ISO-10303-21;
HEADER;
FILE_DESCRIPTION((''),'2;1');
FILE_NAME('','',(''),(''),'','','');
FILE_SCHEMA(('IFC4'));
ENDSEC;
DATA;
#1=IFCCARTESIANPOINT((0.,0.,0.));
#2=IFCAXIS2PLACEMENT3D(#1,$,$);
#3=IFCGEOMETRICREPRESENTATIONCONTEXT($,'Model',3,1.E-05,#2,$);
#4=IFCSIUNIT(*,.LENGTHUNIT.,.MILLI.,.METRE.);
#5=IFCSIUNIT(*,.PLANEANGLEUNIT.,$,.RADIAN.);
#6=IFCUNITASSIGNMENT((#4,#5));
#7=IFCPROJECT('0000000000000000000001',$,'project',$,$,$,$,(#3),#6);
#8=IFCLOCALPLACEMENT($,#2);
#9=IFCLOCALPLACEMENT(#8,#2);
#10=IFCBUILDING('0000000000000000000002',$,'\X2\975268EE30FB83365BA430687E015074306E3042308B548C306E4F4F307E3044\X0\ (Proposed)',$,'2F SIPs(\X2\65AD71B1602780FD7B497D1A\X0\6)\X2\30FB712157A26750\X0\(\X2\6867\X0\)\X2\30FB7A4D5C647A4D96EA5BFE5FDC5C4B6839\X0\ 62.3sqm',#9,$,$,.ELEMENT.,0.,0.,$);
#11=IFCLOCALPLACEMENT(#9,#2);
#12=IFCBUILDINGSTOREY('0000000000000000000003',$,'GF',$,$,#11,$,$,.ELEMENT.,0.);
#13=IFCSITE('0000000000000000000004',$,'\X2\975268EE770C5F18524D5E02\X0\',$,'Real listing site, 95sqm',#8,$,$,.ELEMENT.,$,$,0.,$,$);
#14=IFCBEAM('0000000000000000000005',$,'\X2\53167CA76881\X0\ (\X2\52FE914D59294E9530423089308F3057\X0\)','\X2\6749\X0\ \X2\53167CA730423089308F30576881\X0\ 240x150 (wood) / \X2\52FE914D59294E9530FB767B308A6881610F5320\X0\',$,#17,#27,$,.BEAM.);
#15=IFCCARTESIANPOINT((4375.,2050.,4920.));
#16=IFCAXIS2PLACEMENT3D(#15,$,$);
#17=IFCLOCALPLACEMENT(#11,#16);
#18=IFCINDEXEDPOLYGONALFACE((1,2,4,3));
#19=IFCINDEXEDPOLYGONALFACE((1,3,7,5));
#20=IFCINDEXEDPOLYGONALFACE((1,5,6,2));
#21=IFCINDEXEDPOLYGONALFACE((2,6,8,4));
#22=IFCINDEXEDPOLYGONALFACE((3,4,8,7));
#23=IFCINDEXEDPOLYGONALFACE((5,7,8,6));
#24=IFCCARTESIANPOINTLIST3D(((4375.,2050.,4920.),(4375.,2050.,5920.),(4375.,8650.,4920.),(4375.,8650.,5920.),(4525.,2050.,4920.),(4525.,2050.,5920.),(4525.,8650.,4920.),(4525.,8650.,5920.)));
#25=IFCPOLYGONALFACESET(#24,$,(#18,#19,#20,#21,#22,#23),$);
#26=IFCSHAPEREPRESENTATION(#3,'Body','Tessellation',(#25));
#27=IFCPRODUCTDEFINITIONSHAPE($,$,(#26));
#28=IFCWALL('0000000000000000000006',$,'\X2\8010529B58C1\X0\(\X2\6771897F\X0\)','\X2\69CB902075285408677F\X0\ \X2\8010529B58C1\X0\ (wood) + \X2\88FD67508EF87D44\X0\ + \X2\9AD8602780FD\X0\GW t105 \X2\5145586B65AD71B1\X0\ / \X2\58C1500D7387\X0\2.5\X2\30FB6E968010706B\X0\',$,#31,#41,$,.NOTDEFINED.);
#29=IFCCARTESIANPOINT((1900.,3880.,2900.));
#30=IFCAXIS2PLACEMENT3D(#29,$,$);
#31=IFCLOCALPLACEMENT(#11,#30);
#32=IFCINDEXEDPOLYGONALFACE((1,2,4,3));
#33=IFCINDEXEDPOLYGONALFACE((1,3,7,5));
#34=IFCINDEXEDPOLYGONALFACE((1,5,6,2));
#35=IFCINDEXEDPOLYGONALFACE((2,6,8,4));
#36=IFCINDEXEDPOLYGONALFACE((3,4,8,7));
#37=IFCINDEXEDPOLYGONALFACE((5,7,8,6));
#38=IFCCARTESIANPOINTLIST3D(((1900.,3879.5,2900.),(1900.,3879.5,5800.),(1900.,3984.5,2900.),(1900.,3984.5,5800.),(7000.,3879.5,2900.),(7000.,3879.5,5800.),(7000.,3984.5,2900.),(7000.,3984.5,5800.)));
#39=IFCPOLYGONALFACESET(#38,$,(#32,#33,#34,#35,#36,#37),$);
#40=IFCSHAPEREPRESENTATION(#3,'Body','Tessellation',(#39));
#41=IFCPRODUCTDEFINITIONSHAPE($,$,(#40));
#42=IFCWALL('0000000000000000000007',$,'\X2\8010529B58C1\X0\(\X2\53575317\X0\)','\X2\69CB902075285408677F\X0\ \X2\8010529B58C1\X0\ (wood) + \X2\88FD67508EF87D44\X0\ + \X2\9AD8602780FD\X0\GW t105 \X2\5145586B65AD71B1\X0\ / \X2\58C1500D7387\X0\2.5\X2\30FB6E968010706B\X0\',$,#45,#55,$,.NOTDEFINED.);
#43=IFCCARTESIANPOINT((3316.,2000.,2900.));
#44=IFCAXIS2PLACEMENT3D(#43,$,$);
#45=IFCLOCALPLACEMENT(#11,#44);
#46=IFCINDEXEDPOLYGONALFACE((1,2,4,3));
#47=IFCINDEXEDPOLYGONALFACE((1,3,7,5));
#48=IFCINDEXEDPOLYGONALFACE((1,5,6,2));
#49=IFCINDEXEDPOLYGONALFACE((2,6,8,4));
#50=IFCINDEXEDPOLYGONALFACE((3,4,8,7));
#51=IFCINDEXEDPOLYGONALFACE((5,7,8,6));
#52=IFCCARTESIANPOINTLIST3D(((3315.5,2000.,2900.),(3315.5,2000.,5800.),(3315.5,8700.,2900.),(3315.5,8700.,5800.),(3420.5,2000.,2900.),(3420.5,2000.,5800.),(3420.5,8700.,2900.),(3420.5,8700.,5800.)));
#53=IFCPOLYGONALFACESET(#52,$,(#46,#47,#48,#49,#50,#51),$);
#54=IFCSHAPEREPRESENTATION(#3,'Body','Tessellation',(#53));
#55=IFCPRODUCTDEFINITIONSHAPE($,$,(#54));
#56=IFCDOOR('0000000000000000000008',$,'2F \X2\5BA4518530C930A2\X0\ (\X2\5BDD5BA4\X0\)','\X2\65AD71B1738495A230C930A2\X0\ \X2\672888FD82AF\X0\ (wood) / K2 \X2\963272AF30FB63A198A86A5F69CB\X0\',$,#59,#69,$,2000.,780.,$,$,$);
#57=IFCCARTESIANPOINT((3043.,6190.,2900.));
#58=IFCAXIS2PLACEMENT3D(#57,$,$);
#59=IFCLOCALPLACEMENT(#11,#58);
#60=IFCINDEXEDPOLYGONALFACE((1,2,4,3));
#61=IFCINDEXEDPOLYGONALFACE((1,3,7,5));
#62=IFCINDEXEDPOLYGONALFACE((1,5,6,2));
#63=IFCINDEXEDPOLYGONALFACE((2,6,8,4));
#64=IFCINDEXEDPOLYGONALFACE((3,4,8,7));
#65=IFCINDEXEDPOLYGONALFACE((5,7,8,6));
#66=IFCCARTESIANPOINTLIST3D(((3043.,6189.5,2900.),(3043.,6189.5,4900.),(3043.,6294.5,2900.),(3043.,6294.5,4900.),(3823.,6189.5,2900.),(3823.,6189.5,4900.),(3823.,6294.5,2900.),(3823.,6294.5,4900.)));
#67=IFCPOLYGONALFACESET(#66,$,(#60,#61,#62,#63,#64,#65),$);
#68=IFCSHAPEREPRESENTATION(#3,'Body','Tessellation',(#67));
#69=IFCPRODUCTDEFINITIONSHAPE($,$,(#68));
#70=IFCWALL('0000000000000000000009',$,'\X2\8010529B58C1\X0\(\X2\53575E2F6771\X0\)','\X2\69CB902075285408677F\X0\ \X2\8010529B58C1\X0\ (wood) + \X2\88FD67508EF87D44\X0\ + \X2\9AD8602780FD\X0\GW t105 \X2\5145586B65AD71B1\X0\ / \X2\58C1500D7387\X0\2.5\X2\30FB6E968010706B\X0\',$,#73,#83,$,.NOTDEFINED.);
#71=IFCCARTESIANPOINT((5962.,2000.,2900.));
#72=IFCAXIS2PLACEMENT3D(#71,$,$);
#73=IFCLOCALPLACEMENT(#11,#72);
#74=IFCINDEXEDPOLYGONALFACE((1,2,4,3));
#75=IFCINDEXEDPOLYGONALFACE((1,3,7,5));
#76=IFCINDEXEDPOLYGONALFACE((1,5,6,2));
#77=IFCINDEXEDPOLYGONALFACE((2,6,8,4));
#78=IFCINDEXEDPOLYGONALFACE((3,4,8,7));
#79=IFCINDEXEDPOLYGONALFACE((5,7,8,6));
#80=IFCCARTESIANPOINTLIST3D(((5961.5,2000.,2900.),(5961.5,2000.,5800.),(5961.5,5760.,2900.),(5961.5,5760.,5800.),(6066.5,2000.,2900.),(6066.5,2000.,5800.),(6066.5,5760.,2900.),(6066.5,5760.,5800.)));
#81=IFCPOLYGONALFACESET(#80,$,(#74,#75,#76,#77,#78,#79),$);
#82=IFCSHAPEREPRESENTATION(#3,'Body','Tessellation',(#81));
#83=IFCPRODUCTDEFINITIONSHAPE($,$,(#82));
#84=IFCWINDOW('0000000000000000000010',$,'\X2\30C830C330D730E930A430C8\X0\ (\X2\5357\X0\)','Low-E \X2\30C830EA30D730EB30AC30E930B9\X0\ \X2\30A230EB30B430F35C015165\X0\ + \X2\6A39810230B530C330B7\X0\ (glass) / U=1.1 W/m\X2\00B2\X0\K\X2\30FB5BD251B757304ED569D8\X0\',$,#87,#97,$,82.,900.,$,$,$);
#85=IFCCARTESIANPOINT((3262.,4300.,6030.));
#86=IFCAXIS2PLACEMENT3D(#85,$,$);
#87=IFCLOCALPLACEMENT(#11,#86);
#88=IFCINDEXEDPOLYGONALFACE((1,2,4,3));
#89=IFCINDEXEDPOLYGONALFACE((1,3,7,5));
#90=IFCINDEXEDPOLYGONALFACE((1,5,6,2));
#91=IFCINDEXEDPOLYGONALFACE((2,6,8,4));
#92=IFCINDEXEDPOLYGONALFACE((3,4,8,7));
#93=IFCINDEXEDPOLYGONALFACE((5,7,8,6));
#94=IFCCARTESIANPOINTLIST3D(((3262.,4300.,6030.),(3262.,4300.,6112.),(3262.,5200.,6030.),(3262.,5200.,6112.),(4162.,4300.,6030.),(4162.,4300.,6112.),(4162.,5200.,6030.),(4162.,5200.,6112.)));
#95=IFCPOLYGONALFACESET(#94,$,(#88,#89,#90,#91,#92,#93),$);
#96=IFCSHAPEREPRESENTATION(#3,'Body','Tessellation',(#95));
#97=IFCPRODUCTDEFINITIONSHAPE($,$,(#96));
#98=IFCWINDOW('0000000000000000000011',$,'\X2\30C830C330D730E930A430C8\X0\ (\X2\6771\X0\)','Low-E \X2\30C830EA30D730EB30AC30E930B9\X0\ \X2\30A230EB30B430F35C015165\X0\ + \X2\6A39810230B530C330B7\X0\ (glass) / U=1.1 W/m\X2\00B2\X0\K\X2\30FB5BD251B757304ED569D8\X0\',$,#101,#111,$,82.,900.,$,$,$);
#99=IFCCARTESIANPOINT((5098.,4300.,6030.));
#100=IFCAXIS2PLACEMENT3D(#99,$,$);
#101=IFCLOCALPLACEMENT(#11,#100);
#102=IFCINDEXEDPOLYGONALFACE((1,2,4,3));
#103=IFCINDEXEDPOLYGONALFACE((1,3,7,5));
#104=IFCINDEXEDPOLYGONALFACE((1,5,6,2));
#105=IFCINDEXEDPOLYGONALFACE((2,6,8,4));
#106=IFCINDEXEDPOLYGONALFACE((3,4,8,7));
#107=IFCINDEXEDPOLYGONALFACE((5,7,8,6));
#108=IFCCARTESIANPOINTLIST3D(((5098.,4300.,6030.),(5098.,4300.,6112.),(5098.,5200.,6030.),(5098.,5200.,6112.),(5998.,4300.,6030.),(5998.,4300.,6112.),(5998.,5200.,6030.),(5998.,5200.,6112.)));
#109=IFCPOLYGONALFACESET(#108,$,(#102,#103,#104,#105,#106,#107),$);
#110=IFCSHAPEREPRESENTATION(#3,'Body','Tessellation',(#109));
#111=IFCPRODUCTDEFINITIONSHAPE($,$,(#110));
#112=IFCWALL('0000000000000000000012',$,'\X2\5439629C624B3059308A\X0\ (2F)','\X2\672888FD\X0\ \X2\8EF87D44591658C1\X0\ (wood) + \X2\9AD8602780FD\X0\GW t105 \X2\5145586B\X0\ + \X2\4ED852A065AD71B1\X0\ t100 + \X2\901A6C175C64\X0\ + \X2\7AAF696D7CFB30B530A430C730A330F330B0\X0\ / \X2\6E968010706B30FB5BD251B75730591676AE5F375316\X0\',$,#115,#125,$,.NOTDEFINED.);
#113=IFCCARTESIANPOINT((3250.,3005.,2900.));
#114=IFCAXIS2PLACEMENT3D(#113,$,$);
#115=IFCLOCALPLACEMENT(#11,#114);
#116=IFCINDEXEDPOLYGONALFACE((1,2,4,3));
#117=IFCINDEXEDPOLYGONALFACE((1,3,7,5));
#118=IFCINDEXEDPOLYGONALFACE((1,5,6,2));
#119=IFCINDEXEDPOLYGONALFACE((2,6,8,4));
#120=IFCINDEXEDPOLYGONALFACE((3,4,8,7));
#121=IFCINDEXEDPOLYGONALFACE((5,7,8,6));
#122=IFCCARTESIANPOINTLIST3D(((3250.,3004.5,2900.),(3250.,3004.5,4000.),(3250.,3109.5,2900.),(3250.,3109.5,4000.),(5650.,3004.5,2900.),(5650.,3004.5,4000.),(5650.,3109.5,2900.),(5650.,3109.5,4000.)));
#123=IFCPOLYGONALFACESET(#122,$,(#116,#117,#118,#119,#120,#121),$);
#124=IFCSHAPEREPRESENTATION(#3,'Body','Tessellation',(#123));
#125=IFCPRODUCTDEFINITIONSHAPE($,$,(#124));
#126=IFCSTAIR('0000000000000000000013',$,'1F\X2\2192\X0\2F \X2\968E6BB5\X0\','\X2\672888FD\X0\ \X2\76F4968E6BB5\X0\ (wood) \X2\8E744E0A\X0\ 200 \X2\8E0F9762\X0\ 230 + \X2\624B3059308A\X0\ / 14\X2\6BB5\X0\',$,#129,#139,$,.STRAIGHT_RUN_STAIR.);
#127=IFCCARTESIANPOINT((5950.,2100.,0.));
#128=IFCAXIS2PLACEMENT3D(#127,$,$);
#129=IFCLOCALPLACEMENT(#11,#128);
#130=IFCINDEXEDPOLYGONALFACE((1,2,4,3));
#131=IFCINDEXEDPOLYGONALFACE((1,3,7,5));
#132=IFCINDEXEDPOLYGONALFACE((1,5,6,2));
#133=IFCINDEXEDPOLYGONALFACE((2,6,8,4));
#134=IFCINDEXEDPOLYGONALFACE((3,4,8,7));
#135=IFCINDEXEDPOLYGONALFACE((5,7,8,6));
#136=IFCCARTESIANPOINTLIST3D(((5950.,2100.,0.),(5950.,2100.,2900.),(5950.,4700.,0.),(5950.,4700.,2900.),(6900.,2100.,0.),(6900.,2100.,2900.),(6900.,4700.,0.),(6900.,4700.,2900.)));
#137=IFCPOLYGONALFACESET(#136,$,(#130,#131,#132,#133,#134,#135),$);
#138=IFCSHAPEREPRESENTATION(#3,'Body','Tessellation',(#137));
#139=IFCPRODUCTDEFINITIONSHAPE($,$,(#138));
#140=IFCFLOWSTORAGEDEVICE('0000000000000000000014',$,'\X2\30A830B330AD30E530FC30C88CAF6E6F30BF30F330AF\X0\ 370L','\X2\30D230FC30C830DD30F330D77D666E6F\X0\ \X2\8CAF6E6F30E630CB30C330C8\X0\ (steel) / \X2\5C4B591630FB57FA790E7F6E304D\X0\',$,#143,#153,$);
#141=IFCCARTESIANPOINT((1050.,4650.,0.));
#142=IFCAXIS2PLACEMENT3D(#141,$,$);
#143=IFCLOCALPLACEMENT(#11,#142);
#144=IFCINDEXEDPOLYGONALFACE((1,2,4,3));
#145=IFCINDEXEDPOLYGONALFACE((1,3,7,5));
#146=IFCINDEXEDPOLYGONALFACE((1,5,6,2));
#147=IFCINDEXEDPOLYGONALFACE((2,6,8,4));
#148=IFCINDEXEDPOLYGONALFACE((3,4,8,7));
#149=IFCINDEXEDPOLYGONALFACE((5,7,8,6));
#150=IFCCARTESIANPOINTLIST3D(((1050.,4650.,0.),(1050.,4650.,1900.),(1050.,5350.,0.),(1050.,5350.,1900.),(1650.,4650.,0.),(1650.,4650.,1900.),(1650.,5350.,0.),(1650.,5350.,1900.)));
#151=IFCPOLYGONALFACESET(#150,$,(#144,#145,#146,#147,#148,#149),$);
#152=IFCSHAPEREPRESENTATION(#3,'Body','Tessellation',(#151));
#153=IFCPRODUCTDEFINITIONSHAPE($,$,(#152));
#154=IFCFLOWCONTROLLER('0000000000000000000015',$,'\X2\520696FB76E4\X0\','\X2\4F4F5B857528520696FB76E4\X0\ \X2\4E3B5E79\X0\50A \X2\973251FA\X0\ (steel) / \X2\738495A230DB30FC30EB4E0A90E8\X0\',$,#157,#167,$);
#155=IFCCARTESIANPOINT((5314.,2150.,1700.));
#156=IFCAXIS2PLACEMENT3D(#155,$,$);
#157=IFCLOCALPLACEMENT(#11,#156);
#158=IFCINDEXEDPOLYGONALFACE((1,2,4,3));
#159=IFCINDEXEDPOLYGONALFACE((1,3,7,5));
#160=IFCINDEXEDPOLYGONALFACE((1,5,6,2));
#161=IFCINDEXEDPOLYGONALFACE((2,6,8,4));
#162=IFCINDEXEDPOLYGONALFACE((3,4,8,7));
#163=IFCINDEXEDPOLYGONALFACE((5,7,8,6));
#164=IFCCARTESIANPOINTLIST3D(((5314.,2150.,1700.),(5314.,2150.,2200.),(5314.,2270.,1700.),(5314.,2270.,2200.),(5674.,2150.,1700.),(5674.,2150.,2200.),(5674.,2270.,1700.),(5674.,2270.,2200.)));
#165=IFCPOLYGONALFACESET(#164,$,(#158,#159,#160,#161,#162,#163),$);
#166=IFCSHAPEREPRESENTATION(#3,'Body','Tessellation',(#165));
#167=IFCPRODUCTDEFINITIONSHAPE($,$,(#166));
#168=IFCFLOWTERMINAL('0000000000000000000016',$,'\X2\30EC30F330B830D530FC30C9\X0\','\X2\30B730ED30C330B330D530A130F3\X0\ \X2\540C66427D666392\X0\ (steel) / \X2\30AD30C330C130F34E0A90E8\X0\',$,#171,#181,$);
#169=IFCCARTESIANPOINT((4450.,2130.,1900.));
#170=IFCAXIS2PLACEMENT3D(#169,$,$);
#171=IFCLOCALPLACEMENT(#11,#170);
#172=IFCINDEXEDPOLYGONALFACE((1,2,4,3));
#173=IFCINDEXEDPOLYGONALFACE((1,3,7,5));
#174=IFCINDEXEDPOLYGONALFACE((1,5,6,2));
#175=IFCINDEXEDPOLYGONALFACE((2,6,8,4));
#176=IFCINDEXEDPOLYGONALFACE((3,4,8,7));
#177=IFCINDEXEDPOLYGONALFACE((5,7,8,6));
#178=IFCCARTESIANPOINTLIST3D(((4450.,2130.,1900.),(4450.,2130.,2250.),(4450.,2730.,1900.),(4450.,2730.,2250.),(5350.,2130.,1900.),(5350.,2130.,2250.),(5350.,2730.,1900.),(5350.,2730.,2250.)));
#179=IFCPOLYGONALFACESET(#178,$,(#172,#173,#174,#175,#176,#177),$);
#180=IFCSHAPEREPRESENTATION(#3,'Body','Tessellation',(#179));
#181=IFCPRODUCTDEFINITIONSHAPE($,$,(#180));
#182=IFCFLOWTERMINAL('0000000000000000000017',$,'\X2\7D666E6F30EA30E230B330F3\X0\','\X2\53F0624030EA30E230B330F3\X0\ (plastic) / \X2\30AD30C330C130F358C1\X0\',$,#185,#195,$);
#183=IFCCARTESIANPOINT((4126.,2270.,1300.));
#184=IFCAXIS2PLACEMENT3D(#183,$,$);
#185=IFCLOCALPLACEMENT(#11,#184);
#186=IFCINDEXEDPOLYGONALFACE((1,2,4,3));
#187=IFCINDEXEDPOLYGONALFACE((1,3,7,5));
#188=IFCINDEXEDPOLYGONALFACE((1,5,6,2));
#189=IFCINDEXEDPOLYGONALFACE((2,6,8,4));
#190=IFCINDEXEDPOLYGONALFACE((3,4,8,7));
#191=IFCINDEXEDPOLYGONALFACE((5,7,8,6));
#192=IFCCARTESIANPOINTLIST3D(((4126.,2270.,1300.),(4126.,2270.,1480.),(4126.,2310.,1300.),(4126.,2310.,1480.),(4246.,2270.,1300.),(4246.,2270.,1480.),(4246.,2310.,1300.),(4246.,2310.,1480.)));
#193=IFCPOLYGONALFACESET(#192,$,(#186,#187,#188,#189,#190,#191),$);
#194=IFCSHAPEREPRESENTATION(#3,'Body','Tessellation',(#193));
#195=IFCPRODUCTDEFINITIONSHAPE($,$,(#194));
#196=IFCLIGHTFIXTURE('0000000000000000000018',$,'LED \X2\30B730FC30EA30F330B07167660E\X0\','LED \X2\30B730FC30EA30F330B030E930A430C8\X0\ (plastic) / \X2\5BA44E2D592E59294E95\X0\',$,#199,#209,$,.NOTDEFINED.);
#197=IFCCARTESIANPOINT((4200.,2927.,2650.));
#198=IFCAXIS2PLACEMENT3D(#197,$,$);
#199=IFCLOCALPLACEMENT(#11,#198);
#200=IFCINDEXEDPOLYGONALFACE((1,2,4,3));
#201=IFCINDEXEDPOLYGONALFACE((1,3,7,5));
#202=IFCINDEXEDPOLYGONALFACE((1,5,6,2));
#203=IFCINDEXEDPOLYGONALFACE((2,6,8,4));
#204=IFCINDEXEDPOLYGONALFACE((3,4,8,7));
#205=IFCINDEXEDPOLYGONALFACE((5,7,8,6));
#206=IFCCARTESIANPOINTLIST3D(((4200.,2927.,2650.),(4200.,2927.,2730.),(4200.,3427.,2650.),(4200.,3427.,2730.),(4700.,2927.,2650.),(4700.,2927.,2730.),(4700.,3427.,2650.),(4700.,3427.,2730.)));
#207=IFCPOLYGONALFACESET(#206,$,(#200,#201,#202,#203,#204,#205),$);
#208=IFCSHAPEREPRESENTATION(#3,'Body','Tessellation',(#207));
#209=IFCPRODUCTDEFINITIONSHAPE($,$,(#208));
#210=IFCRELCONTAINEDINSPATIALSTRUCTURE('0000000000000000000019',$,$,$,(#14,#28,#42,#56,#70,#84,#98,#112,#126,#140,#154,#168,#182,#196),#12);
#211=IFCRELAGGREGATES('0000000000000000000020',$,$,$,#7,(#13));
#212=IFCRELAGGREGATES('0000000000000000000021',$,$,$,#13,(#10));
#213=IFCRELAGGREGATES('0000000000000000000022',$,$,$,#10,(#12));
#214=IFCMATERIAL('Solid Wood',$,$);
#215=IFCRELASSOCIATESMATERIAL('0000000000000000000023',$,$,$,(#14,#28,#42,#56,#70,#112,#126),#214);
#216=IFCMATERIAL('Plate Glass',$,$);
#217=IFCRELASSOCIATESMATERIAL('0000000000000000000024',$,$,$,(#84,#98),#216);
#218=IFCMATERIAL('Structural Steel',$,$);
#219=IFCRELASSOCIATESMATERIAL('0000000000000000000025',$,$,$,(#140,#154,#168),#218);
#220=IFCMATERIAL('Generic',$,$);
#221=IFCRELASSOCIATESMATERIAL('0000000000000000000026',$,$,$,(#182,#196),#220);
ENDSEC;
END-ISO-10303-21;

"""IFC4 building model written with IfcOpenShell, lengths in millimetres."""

from ifc_helpers import new_model, si_unit, frame, frame_2d, origin, place, context, project, spatial, rectangle, extrude, material, element, fill, save


model = new_model("IFC4")

# Units and contexts
model_context = context("Model", 3, precision=1e-05, world=origin())
ifc_project = project(units=[si_unit("LENGTHUNIT", "METRE", prefix="MILLI"), si_unit("PLANEANGLEUNIT", "RADIAN")], contexts=[model_context])

# Site, building, storey
site_placement = place(None, origin())
site = spatial("IfcSite", under=ifc_project, at=site_placement, Name="青森県弘前市", ObjectType="Real listing site, 95sqm", CompositionType="ELEMENT", RefElevation=0.0)
building_placement = place(site_placement, origin())
building = spatial("IfcBuilding", under=site, at=building_placement, Name="青森・茶室と縁側のある和の住まい (Proposed)", ObjectType="2F SIPs(断熱性能等級6)・無垢材(桧)・積層積雪対応屋根 62.3sqm", CompositionType="ELEMENT", ElevationOfRefHeight=0.0, ElevationOfTerrain=0.0)
storey_placement = place(building_placement, origin())
storey = spatial("IfcBuildingStorey", under=building, at=storey_placement, Name="GF", CompositionType="ELEMENT", Elevation=0.0)

# Shared definitions
ifc_material_1 = material(Name="Solid Wood")

# Beam
beam_placement = place(storey_placement, frame((4375.0, 2050.0, 4920.0)))
element("IfcBeam", 1, at=beam_placement, inside=storey, material=ifc_material_1, Name="化粧梁 (勾配天井あらわし)", Description="杉 化粧あらわし梁 240x150 (wood) / 勾配天井・登り梁意匠", PredefinedType="BEAM", context=model_context, shape_type="SweptSolid", body=[
    extrude(rectangle(XDim=150.0, YDim=6600.0, at=frame_2d((75.0, 3300.0))), frame((4375.0, 2050.0, 4920.0)), (0.0, 0.0, 1.0), 1000.0),
])

# Wall
wall_1_placement = place(storey_placement, frame((1900.0, 3880.0, 2900.0)))
element("IfcWall", 2, at=wall_1_placement, inside=storey, material=ifc_material_1, Name="耐力壁(東西)", Description="構造用合板 耐力壁 (wood) + 製材軸組 + 高性能GW t105 充填断熱 / 壁倍率2.5・準耐火", PredefinedType="NOTDEFINED", context=model_context, shape_type="SweptSolid", body=[
    extrude(rectangle(XDim=5100.0, YDim=105.0, at=frame_2d((2550.0, 52.0))), frame((1900.0, 3880.0, 2900.0)), (0.0, 0.0, 1.0), 2900.0),
])

# Wall, opening, door
wall_2_placement = place(storey_placement, frame((3316.0, 2000.0, 2900.0)))
wall_2 = element("IfcWall", 3, at=wall_2_placement, inside=storey, material=ifc_material_1, Name="耐力壁(南北)", Description="構造用合板 耐力壁 (wood) + 製材軸組 + 高性能GW t105 充填断熱 / 壁倍率2.5・準耐火", PredefinedType="NOTDEFINED", context=model_context, shape_type="SweptSolid", body=[
    extrude(rectangle(XDim=105.0, YDim=6700.0, at=frame_2d((52.0, 3350.0))), frame((3316.0, 2000.0, 2900.0)), (0.0, 0.0, 1.0), 2900.0),
])
opening_placement = place(storey_placement, frame((3043.0, 6190.0, 2900.0)))
opening = element("IfcOpeningElement", 4, at=opening_placement, cuts=wall_2, PredefinedType="NOTDEFINED", context=model_context, shape_type="SweptSolid", body=[
    extrude(rectangle(XDim=780.0, YDim=105.0, at=frame_2d((390.0, 52.0))), frame((3043.0, 6190.0, 2900.0)), (0.0, 0.0, 1.0), 2000.0),
])
door_placement = place(storey_placement, frame((3043.0, 6190.0, 2900.0)))
door = element("IfcDoor", 5, at=door_placement, inside=storey, material=ifc_material_1, Name="2F 室内ドア (寝室)", Description="断熱玄関ドア 木製芯 (wood) / K2 防犯・採風機構", OverallHeight=2000.0, OverallWidth=780.0, context=model_context, shape_type="SweptSolid", body=[
    extrude(rectangle(XDim=780.0, YDim=105.0, at=frame_2d((390.0, 52.0))), frame((3043.0, 6190.0, 2900.0)), (0.0, 0.0, 1.0), 2000.0),
])
fill(opening, door)

# Wall
wall_3_placement = place(storey_placement, frame((5962.0, 2000.0, 2900.0)))
element("IfcWall", 6, at=wall_3_placement, inside=storey, material=ifc_material_1, Name="耐力壁(南帯東)", Description="構造用合板 耐力壁 (wood) + 製材軸組 + 高性能GW t105 充填断熱 / 壁倍率2.5・準耐火", PredefinedType="NOTDEFINED", context=model_context, shape_type="SweptSolid", body=[
    extrude(rectangle(XDim=105.0, YDim=3760.0, at=frame_2d((52.0, 1880.0))), frame((5962.0, 2000.0, 2900.0)), (0.0, 0.0, 1.0), 2900.0),
])

# Windows
ifc_material_2 = material(Name="Plate Glass")
window_1_placement = place(storey_placement, frame((3262.0, 4300.0, 6030.0)))
element("IfcWindow", 7, at=window_1_placement, inside=storey, material=ifc_material_2, Name="トップライト (南)", Description="Low-E トリプルガラス アルゴン封入 + 樹脂サッシ (glass) / U=1.1 W/m²K・寒冷地仕様", OverallHeight=82.0, OverallWidth=900.0, context=model_context, shape_type="SweptSolid", body=[
    extrude(rectangle(XDim=900.0, YDim=900.0, at=frame_2d((450.0, 450.0))), frame((3262.0, 4300.0, 6030.0)), (0.0, 0.0, 1.0), 82.0),
])
window_2_placement = place(storey_placement, frame((5098.0, 4300.0, 6030.0)))
element("IfcWindow", 8, at=window_2_placement, inside=storey, material=ifc_material_2, Name="トップライト (東)", Description="Low-E トリプルガラス アルゴン封入 + 樹脂サッシ (glass) / U=1.1 W/m²K・寒冷地仕様", OverallHeight=82.0, OverallWidth=900.0, context=model_context, shape_type="SweptSolid", body=[
    extrude(rectangle(XDim=900.0, YDim=900.0, at=frame_2d((450.0, 450.0))), frame((5098.0, 4300.0, 6030.0)), (0.0, 0.0, 1.0), 82.0),
])

# Wall
wall_4_placement = place(storey_placement, frame((3250.0, 3005.0, 2900.0)))
element("IfcWall", 9, at=wall_4_placement, inside=storey, material=ifc_material_1, Name="吹抜手すり (2F)", Description="木製 軸組外壁 (wood) + 高性能GW t105 充填 + 付加断熱 t100 + 通気層 + 窯業系サイディング / 準耐火・寒冷地外皮強化", PredefinedType="NOTDEFINED", context=model_context, shape_type="SweptSolid", body=[
    extrude(rectangle(XDim=2400.0, YDim=105.0, at=frame_2d((1200.0, 52.0))), frame((3250.0, 3005.0, 2900.0)), (0.0, 0.0, 1.0), 1100.0),
])

# Stair
stair_placement = place(storey_placement, frame((5950.0, 2100.0, 0.0)))
element("IfcStair", 10, at=stair_placement, inside=storey, material=ifc_material_1, Name="1F→2F 階段", Description="木製 直階段 (wood) 蹴上 200 踏面 230 + 手すり / 14段", PredefinedType="STRAIGHT_RUN_STAIR", context=model_context, shape_type="SweptSolid", body=[
    extrude(rectangle(XDim=950.0, YDim=2600.0, at=frame_2d((475.0, 1300.0))), frame((5950.0, 2100.0, 0.0)), (0.0, 0.0, 1.0), 2900.0),
])

# Flow storage device
ifc_material_3 = material(Name="Structural Steel")
flow_storage_device_placement = place(storey_placement, frame((1050.0, 4650.0, 0.0)))
element("IfcFlowStorageDevice", 11, at=flow_storage_device_placement, inside=storey, material=ifc_material_3, Name="エコキュート貯湯タンク 370L", Description="ヒートポンプ給湯 貯湯ユニット (steel) / 屋外・基礎置き", context=model_context, shape_type="SweptSolid", body=[
    extrude(rectangle(XDim=600.0, YDim=700.0, at=frame_2d((300.0, 350.0))), frame((1050.0, 4650.0, 0.0)), (0.0, 0.0, 1.0), 1900.0),
])

# Flow controller
flow_controller_placement = place(storey_placement, frame((5314.0, 2150.0, 1700.0)))
element("IfcFlowController", 12, at=flow_controller_placement, inside=storey, material=ifc_material_3, Name="分電盤", Description="住宅用分電盤 主幹50A 露出 (steel) / 玄関ホール上部", context=model_context, shape_type="SweptSolid", body=[
    extrude(rectangle(XDim=360.0, YDim=120.0, at=frame_2d((180.0, 60.0))), frame((5314.0, 2150.0, 1700.0)), (0.0, 0.0, 1.0), 500.0),
])

# Flow terminals
flow_terminal_1_placement = place(storey_placement, frame((4450.0, 2130.0, 1900.0)))
element("IfcFlowTerminal", 13, at=flow_terminal_1_placement, inside=storey, material=ifc_material_3, Name="レンジフード", Description="シロッコファン 同時給排 (steel) / キッチン上部", context=model_context, shape_type="SweptSolid", body=[
    extrude(rectangle(XDim=900.0, YDim=600.0, at=frame_2d((450.0, 300.0))), frame((4450.0, 2130.0, 1900.0)), (0.0, 0.0, 1.0), 350.0),
])
ifc_material_4 = material(Name="Generic")
flow_terminal_2_placement = place(storey_placement, frame((4126.0, 2270.0, 1300.0)))
element("IfcFlowTerminal", 14, at=flow_terminal_2_placement, inside=storey, material=ifc_material_4, Name="給湯リモコン", Description="台所リモコン (plastic) / キッチン壁", context=model_context, shape_type="SweptSolid", body=[
    extrude(rectangle(XDim=120.0, YDim=40.0, at=frame_2d((60.0, 20.0))), frame((4126.0, 2270.0, 1300.0)), (0.0, 0.0, 1.0), 180.0),
])

# Light fixture
light_fixture_1_placement = place(storey_placement, frame((4200.0, 2927.0, 2650.0)))
element("IfcLightFixture", 15, at=light_fixture_1_placement, inside=storey, material=ifc_material_4, Name="LED シーリング照明", Description="LED シーリングライト (plastic) / 室中央天井", PredefinedType="NOTDEFINED", context=model_context, shape_type="SweptSolid", body=[
    extrude(rectangle(XDim=500.0, YDim=500.0, at=frame_2d((250.0, 250.0))), frame((4200.0, 2927.0, 2650.0)), (0.0, 0.0, 1.0), 80.0),
])

save(model, "model.ifc")
